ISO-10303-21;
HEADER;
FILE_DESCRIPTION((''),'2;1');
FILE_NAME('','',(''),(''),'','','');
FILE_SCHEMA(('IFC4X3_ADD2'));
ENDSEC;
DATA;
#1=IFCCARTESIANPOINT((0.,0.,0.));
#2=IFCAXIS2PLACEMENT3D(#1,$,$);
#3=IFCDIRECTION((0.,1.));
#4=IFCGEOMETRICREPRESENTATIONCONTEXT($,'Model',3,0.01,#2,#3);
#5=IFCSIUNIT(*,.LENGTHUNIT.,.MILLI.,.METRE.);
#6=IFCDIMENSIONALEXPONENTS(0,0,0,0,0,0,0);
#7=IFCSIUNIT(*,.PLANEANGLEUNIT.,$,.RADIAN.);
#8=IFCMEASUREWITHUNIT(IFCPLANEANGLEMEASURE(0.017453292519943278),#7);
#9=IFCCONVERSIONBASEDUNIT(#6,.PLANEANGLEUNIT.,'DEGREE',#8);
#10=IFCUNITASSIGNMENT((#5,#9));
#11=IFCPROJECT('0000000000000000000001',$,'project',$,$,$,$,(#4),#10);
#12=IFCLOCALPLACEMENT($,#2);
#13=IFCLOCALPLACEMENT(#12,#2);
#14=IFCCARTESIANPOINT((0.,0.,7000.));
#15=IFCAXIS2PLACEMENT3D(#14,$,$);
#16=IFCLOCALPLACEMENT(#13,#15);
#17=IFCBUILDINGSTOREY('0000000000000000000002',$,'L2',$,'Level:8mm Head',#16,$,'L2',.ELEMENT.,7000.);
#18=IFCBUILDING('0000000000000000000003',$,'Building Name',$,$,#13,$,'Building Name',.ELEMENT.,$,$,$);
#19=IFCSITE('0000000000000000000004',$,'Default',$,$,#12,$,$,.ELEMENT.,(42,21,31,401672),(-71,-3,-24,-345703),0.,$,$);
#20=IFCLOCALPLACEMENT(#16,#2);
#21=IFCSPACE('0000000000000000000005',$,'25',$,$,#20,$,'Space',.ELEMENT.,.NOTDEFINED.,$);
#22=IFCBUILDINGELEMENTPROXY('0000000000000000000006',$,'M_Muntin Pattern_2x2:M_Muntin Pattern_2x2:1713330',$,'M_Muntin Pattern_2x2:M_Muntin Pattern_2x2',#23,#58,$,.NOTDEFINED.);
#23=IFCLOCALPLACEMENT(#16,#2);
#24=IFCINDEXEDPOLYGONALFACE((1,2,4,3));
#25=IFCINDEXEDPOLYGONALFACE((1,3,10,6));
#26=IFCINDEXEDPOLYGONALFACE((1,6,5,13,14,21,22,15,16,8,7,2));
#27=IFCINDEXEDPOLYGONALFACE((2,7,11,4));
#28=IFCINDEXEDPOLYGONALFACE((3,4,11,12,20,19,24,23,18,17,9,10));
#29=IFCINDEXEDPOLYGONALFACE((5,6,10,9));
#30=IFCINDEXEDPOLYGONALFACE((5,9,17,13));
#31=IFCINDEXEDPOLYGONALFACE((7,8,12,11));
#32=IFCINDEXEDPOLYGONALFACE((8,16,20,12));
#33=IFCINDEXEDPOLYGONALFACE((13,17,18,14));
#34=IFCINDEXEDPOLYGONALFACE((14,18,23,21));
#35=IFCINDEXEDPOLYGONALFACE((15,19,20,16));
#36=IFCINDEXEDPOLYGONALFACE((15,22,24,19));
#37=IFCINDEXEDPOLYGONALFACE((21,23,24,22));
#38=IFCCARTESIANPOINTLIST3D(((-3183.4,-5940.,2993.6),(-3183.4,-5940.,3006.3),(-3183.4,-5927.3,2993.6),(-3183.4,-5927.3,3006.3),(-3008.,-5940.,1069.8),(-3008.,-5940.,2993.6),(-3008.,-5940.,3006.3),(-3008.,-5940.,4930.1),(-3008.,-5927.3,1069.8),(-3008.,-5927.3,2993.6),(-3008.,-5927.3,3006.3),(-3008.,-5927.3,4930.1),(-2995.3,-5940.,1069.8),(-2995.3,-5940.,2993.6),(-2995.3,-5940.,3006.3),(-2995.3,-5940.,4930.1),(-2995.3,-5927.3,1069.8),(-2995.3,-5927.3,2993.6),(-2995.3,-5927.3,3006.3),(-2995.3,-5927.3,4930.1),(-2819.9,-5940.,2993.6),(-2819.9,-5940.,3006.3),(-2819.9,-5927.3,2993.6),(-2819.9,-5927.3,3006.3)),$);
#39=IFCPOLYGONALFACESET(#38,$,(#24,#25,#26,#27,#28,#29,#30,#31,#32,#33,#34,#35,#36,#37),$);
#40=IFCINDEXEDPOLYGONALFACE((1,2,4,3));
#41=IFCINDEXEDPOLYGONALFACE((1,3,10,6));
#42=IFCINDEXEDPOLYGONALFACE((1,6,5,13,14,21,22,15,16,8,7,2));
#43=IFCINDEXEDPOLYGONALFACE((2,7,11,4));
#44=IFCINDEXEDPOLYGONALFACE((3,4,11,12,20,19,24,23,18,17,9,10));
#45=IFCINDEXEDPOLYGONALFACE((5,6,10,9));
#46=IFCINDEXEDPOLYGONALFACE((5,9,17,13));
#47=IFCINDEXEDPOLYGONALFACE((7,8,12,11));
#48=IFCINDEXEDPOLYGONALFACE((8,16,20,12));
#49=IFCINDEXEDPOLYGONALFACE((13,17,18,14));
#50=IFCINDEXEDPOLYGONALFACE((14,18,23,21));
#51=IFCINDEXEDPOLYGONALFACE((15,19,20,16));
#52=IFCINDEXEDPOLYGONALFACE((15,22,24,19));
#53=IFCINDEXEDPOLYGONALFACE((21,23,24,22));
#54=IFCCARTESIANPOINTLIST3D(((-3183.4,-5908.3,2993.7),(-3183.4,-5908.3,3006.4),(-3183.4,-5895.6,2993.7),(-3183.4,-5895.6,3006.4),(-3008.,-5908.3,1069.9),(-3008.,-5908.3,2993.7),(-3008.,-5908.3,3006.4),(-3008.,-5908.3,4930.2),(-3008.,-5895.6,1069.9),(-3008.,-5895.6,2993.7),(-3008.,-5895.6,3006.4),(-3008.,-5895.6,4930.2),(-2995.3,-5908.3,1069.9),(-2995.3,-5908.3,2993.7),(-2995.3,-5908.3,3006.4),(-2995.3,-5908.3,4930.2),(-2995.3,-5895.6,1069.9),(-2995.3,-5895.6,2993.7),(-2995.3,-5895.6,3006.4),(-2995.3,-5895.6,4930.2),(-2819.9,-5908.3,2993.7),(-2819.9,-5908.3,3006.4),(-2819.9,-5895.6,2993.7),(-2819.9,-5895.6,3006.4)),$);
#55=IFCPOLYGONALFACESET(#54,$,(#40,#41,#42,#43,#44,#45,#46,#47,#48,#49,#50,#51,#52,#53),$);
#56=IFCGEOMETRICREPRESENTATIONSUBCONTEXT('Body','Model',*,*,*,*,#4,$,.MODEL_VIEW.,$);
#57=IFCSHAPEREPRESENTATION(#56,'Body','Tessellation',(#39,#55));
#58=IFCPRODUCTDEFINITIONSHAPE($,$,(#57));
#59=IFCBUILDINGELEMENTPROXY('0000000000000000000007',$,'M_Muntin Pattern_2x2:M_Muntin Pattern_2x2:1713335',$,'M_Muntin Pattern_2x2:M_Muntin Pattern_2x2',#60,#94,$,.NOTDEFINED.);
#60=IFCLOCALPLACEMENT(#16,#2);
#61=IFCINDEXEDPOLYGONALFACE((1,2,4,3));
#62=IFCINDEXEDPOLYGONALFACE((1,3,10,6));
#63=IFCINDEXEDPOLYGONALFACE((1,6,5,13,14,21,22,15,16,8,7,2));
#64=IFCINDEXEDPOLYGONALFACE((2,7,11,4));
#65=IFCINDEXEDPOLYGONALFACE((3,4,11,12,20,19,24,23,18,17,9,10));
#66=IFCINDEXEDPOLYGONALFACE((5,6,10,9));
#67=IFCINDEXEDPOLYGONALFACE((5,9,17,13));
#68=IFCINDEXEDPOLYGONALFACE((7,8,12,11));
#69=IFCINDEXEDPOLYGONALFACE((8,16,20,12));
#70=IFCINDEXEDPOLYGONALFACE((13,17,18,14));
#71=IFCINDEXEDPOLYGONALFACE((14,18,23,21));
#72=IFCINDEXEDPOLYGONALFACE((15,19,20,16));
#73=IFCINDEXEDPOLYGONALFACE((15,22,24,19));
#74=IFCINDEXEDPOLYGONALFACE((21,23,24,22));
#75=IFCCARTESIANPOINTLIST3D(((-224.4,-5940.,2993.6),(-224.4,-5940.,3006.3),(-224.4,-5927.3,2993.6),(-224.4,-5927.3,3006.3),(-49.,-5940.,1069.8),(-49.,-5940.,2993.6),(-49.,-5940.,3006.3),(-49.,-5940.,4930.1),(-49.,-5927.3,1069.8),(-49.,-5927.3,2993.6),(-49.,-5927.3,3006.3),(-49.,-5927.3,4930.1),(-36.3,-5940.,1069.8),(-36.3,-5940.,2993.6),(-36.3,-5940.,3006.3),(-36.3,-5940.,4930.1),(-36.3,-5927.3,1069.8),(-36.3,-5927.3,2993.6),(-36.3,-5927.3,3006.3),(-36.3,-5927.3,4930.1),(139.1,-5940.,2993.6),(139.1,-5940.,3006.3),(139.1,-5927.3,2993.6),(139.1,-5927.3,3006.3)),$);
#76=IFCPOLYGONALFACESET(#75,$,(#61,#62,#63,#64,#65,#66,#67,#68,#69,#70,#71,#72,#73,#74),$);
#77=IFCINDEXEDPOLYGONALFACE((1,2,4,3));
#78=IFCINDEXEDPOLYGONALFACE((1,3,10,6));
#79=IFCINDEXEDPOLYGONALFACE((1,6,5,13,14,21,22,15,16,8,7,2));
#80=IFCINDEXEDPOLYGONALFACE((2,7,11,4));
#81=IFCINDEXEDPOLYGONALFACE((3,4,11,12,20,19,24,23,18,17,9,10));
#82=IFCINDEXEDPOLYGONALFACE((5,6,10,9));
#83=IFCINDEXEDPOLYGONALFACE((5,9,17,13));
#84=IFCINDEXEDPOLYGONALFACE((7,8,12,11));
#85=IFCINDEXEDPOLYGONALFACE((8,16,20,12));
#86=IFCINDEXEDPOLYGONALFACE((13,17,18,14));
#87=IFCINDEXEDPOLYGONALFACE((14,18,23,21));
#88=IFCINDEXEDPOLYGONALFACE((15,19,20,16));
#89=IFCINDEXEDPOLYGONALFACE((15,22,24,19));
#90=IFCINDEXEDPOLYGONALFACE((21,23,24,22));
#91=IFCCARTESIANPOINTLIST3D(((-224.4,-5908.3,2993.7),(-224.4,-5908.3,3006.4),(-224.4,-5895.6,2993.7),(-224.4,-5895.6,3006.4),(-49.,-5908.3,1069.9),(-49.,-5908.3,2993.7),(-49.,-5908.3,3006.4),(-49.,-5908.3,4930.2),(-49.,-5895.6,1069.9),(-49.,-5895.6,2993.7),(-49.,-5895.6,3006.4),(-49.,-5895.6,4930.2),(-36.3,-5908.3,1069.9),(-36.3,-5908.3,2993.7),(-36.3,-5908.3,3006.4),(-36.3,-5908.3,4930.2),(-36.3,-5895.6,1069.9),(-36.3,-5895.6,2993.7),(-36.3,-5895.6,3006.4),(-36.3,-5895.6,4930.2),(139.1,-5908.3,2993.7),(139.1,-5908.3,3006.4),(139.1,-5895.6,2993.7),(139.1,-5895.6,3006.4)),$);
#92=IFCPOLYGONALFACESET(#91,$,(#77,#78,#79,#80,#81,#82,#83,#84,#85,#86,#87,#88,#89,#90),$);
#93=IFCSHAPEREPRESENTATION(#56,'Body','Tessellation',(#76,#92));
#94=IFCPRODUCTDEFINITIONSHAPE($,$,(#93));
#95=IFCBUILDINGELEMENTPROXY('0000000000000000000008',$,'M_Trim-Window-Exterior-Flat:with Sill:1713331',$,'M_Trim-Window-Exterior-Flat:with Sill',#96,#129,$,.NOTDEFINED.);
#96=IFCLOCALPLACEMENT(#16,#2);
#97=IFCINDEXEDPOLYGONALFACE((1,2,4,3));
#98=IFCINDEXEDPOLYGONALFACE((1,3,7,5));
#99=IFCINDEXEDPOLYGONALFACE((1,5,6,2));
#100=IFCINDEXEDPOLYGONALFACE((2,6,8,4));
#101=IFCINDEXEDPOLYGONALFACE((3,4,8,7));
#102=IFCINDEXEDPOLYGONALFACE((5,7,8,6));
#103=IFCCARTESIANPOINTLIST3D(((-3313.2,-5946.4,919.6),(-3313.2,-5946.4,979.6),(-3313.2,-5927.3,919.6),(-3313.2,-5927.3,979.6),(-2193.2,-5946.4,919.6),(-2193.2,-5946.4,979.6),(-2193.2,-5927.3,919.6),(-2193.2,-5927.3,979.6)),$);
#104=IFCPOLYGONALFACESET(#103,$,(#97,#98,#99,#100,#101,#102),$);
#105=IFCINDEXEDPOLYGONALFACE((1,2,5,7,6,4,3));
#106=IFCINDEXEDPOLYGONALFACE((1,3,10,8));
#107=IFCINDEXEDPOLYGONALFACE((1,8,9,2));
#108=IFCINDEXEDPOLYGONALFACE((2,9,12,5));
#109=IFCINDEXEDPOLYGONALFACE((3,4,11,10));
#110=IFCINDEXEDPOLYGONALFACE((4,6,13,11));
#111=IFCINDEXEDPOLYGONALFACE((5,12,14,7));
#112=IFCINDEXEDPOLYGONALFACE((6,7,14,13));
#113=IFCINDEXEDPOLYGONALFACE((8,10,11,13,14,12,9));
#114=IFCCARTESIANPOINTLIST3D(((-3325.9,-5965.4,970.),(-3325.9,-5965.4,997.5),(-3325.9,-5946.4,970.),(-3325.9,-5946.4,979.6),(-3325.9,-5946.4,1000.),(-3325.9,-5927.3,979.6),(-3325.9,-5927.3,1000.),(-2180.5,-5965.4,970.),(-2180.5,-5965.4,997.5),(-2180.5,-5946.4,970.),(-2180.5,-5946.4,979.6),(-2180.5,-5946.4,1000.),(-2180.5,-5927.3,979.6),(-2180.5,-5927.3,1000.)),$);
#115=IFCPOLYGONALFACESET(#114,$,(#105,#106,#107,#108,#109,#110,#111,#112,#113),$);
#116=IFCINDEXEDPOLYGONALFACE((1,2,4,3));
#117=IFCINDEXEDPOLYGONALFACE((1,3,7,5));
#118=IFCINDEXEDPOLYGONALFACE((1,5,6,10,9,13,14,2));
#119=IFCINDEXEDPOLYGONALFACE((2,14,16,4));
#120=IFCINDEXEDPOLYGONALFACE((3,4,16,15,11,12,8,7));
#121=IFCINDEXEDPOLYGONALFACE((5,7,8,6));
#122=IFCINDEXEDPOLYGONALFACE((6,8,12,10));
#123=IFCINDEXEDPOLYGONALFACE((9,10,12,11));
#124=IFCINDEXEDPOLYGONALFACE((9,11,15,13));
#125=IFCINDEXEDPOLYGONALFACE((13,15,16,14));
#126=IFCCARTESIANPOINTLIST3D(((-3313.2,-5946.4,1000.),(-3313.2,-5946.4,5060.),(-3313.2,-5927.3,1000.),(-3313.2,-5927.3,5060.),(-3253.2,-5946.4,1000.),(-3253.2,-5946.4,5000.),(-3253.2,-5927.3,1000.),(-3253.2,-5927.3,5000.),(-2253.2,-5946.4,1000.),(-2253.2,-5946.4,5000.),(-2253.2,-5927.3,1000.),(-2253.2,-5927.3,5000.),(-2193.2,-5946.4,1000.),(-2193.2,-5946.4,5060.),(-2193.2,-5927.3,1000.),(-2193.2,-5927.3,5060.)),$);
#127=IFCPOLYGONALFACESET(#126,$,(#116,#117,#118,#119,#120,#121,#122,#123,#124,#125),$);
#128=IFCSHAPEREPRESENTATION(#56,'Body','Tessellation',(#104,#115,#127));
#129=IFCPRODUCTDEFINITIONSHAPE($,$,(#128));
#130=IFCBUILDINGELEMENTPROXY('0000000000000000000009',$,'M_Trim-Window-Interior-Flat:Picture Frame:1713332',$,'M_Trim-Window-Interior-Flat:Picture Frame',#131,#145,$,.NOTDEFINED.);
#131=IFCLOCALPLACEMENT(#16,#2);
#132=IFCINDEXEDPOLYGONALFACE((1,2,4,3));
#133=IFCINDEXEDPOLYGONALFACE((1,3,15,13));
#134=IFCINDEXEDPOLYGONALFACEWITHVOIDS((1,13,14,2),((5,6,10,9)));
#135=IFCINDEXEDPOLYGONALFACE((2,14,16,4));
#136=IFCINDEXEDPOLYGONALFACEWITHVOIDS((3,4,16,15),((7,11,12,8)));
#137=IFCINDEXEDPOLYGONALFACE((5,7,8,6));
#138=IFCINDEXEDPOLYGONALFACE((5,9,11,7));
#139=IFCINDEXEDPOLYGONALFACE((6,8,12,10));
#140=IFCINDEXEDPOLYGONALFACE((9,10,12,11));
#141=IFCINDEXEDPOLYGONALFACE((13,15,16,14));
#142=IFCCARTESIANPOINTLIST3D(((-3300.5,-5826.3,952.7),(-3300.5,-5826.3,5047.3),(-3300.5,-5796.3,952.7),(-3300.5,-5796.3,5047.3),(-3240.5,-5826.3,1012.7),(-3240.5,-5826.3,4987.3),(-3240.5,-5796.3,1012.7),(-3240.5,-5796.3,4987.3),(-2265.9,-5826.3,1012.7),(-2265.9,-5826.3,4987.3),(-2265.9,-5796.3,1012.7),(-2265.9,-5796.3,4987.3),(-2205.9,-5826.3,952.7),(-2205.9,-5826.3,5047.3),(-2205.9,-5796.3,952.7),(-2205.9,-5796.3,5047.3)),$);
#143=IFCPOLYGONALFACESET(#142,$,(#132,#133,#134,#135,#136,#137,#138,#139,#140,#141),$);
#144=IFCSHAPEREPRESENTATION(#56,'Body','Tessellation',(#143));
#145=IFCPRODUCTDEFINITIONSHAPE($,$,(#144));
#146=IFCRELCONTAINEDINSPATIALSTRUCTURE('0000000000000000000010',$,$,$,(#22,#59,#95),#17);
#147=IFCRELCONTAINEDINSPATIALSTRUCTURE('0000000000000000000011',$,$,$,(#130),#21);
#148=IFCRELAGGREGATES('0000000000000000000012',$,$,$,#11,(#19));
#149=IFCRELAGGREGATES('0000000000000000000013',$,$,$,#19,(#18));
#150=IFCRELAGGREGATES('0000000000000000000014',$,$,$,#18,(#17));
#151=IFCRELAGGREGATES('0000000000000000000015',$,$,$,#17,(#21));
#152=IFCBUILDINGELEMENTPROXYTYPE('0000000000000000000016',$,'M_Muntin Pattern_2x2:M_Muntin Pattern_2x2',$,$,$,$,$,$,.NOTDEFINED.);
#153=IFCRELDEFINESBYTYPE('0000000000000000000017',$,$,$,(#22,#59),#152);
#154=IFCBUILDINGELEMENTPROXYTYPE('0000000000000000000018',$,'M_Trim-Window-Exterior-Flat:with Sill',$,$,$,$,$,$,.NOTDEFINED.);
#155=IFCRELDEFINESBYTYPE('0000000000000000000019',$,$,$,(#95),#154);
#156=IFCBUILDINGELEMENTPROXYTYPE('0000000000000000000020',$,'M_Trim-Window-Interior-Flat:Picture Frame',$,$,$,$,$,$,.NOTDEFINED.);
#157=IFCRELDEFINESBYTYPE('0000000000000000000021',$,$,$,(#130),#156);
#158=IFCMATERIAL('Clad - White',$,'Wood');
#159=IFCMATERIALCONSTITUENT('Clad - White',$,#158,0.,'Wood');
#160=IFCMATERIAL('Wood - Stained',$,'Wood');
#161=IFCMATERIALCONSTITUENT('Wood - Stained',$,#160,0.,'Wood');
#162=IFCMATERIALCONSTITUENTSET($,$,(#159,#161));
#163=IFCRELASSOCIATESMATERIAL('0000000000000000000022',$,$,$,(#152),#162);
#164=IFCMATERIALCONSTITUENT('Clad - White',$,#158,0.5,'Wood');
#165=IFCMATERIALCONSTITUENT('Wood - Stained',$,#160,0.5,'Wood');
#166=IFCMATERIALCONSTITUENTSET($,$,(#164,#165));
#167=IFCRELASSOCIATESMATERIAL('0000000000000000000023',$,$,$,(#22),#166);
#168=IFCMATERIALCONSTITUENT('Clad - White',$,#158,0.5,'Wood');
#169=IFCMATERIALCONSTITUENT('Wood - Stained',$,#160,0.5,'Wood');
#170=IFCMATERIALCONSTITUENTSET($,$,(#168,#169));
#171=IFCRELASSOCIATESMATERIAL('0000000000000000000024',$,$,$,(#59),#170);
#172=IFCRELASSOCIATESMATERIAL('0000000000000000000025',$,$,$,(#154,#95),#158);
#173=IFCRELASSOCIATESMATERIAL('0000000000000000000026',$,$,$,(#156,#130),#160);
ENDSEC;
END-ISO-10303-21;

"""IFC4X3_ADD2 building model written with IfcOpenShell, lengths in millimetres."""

from ifc_helpers import new_model, entity, si_unit, converted_unit, direction, frame, frame_2d, origin, place, context, subcontext, project, spatial, polyline, rectangle, outline, extrude, source, transform, mapped, material, constituent, constituent_set, type_object, type_shapes, element, save


model = new_model("IFC4X3_ADD2")

# Units and contexts
model_context = context("Model", 3, precision=0.01, world=origin(), true_north=direction((0.0, 1.0)))
body_context = subcontext(model_context, "Body", "Model", "MODEL_VIEW")
ifc_project = project(units=[si_unit("LENGTHUNIT", "METRE", prefix="MILLI"), converted_unit("PLANEANGLEUNIT", "DEGREE", entity("IfcPlaneAngleMeasure", 0.017453292519943278), si_unit("PLANEANGLEUNIT", "RADIAN"), dimensions=[0, 0, 0, 0, 0, 0, 0])], contexts=[model_context])

# Site, building, storey
site_placement = place(None, origin())
site = spatial("IfcSite", under=ifc_project, at=site_placement, Name="Default", CompositionType="ELEMENT", RefLatitude=(42, 21, 31, 401672), RefLongitude=(-71, -3, -24, -345703), RefElevation=0.0)
building_placement = place(site_placement, origin())
building = spatial("IfcBuilding", under=site, at=building_placement, Name="Building Name", LongName="Building Name", CompositionType="ELEMENT")
storey_placement = place(building_placement, frame((0.0, 0.0, 7000.0)))
storey = spatial("IfcBuildingStorey", under=building, at=storey_placement, Name="L2", ObjectType="Level:8mm Head", LongName="L2", CompositionType="ELEMENT", Elevation=7000.0)

# Building element proxies
ifc_material_1 = material(Name="Clad - White", Category="Wood")
ifc_material_2 = material(Name="Wood - Stained", Category="Wood")
ifc_constituent_1 = constituent(ifc_material_1, Name="Clad - White", Category="Wood", fraction=0.5)
ifc_constituent_2 = constituent(ifc_material_2, Name="Wood - Stained", Category="Wood", fraction=0.5)
ifc_constituent_set_1 = constituent_set(constituents=[ifc_constituent_1, ifc_constituent_2])
ifc_constituent_3 = constituent(ifc_material_1, Name="Clad - White", Category="Wood", fraction=0.0)
ifc_constituent_4 = constituent(ifc_material_2, Name="Wood - Stained", Category="Wood", fraction=0.0)
ifc_constituent_set_2 = constituent_set(constituents=[ifc_constituent_3, ifc_constituent_4])
building_element_proxy_type_1 = type_object("IfcBuildingElementProxyType", Name="M_Muntin Pattern_2x2:M_Muntin Pattern_2x2", PredefinedType="NOTDEFINED", material=ifc_constituent_set_2)
shared_shape_1 = source(origin(), body_context, "Body", "SweptSolid", [
    extrude(outline(polyline([(6.4, -6.4), (1930.1, -6.4), (1930.1, 6.3), (6.4, 6.3), (6.4, 181.7), (-6.3, 181.7), (-6.3, 6.3), (-1930.2, 6.3), (-1930.2, -6.4), (-6.3, -6.4), (-6.3, -181.7), (6.4, -181.7), (6.4, -6.4)])), frame((0.0, -22.2, 1930.1), z_axis=(0.0, 1.0, 0.0), x_axis=(0.0, 0.0, 1.0)), (0.0, 0.0, 1.0), 12.7),
    extrude(outline(polyline([(6.4, -6.4), (1930.2, -6.4), (1930.2, 6.3), (6.4, 6.3), (6.4, 181.7), (-6.3, 181.7), (-6.3, 6.3), (-1930.2, 6.3), (-1930.2, -6.4), (-6.3, -6.4), (-6.3, -181.7), (6.4, -181.7), (6.4, -6.4)])), frame((0.0, 9.5, 1930.2), z_axis=(0.0, 1.0, 0.0), x_axis=(0.0, 0.0, 1.0)), (0.0, 0.0, 1.0), 12.7),
])
type_shapes(building_element_proxy_type_1, [shared_shape_1])
proxy_1_placement = place(storey_placement, frame((-3001.6, -5917.8, 1069.9)))
element("IfcBuildingElementProxy", 1, at=proxy_1_placement, inside=storey, type_object=building_element_proxy_type_1, material=ifc_constituent_set_1, Name="M_Muntin Pattern_2x2:M_Muntin Pattern_2x2:1713330", ObjectType="M_Muntin Pattern_2x2:M_Muntin Pattern_2x2", PredefinedType="NOTDEFINED", context=body_context, shape_type="MappedRepresentation", body=[
    mapped(shared_shape_1, transform((0.0, 0.0, 0.0), scale=1.0)),
])
ifc_constituent_5 = constituent(ifc_material_1, Name="Clad - White", Category="Wood", fraction=0.5)
ifc_constituent_6 = constituent(ifc_material_2, Name="Wood - Stained", Category="Wood", fraction=0.5)
ifc_constituent_set_3 = constituent_set(constituents=[ifc_constituent_5, ifc_constituent_6])
proxy_2_placement = place(storey_placement, frame((-42.6, -5917.8, 1069.9)))
element("IfcBuildingElementProxy", 2, at=proxy_2_placement, inside=storey, type_object=building_element_proxy_type_1, material=ifc_constituent_set_3, Name="M_Muntin Pattern_2x2:M_Muntin Pattern_2x2:1713335", ObjectType="M_Muntin Pattern_2x2:M_Muntin Pattern_2x2", PredefinedType="NOTDEFINED", context=body_context, shape_type="MappedRepresentation", body=[
    mapped(shared_shape_1, transform((0.0, 0.0, 0.0), scale=1.0)),
])
building_element_proxy_type_2 = type_object("IfcBuildingElementProxyType", Name="M_Trim-Window-Exterior-Flat:with Sill", PredefinedType="NOTDEFINED", material=ifc_material_1)
shared_shape_2 = source(origin(), body_context, "Body", "SweptSolid", [
    extrude(rectangle(XDim=1120.0, YDim=60.0, at=frame_2d((0.0, 0.0), x_axis=(1.0, 0.0))), frame((0.0, -4050.4, 0.0), z_axis=(0.0, 0.0, 1.0), x_axis=(-1.0, 0.0, 0.0)), (0.0, 0.0, 1.0), 19.0),
    extrude(outline(polyline([(-19.0, -15.2), (0.0, -15.2), (0.0, -5.7), (19.0, -5.7), (19.0, 14.8), (0.0, 14.8), (-19.0, 12.3), (-19.0, -15.2)])), frame((-572.7, -4014.8, 19.0), z_axis=(1.0, 0.0, 0.0), x_axis=(0.0, 0.0, -1.0)), (0.0, 0.0, 1.0), 1145.4),
    extrude(outline(polyline([(-2045.0, -560.0), (2015.0, -560.0), (2015.0, -500.0), (-1985.0, -500.0), (-1985.0, 500.0), (2015.0, 500.0), (2015.0, 560.0), (-2045.0, 560.0), (-2045.0, -560.0)])), frame((0.0, -1985.0, 0.0), z_axis=(0.0, 0.0, 1.0), x_axis=(0.0, -1.0, 0.0)), (0.0, 0.0, 1.0), 19.0),
])
type_shapes(building_element_proxy_type_2, [shared_shape_2])
proxy_3_placement = place(storey_placement, frame((-2753.2, -5927.3, 5000.0), z_axis=(0.0, -1.0, 0.0), x_axis=(1.0, 0.0, 0.0)))
element("IfcBuildingElementProxy", 3, at=proxy_3_placement, inside=storey, type_object=building_element_proxy_type_2, material=ifc_material_1, Name="M_Trim-Window-Exterior-Flat:with Sill:1713331", ObjectType="M_Trim-Window-Exterior-Flat:with Sill", PredefinedType="NOTDEFINED", context=body_context, shape_type="MappedRepresentation", body=[
    mapped(shared_shape_2, transform((0.0, 0.0, 0.0), scale=1.0)),
])

# Shared definitions
space_1_placement = place(storey_placement, origin())
space_1 = spatial("IfcSpace", under=storey, at=space_1_placement, Name="25", LongName="Space", CompositionType="ELEMENT", PredefinedType="NOTDEFINED")

# Building element proxy
building_element_proxy_type_3 = type_object("IfcBuildingElementProxyType", Name="M_Trim-Window-Interior-Flat:Picture Frame", PredefinedType="NOTDEFINED", material=ifc_material_2)
shared_shape_3 = source(origin(), body_context, "Body", "SweptSolid", [
    extrude(outline(polyline([(-547.3, -2047.3), (547.3, -2047.3), (547.3, 2047.3), (-547.3, 2047.3), (-547.3, -2047.3)]), holes=[polyline([(-487.3, -1987.3), (-487.3, 1987.3), (487.3, 1987.3), (487.3, -1987.3), (-487.3, -1987.3)])]), frame((0.0, -2000.0, 0.0), z_axis=(0.0, 0.0, 1.0), x_axis=(-1.0, 0.0, 0.0)), (0.0, 0.0, 1.0), 30.0),
])
type_shapes(building_element_proxy_type_3, [shared_shape_3])
proxy_4_placement = place(space_1_placement, frame((-2753.2, -5826.3, 5000.0), z_axis=(0.0, 1.0, 0.0), x_axis=(-1.0, 0.0, 0.0)))
element("IfcBuildingElementProxy", 4, at=proxy_4_placement, inside=space_1, type_object=building_element_proxy_type_3, material=ifc_material_2, Name="M_Trim-Window-Interior-Flat:Picture Frame:1713332", ObjectType="M_Trim-Window-Interior-Flat:Picture Frame", PredefinedType="NOTDEFINED", context=body_context, shape_type="MappedRepresentation", body=[
    mapped(shared_shape_3, transform((0.0, 0.0, 0.0), scale=1.0)),
])

save(model, "model.ifc")
